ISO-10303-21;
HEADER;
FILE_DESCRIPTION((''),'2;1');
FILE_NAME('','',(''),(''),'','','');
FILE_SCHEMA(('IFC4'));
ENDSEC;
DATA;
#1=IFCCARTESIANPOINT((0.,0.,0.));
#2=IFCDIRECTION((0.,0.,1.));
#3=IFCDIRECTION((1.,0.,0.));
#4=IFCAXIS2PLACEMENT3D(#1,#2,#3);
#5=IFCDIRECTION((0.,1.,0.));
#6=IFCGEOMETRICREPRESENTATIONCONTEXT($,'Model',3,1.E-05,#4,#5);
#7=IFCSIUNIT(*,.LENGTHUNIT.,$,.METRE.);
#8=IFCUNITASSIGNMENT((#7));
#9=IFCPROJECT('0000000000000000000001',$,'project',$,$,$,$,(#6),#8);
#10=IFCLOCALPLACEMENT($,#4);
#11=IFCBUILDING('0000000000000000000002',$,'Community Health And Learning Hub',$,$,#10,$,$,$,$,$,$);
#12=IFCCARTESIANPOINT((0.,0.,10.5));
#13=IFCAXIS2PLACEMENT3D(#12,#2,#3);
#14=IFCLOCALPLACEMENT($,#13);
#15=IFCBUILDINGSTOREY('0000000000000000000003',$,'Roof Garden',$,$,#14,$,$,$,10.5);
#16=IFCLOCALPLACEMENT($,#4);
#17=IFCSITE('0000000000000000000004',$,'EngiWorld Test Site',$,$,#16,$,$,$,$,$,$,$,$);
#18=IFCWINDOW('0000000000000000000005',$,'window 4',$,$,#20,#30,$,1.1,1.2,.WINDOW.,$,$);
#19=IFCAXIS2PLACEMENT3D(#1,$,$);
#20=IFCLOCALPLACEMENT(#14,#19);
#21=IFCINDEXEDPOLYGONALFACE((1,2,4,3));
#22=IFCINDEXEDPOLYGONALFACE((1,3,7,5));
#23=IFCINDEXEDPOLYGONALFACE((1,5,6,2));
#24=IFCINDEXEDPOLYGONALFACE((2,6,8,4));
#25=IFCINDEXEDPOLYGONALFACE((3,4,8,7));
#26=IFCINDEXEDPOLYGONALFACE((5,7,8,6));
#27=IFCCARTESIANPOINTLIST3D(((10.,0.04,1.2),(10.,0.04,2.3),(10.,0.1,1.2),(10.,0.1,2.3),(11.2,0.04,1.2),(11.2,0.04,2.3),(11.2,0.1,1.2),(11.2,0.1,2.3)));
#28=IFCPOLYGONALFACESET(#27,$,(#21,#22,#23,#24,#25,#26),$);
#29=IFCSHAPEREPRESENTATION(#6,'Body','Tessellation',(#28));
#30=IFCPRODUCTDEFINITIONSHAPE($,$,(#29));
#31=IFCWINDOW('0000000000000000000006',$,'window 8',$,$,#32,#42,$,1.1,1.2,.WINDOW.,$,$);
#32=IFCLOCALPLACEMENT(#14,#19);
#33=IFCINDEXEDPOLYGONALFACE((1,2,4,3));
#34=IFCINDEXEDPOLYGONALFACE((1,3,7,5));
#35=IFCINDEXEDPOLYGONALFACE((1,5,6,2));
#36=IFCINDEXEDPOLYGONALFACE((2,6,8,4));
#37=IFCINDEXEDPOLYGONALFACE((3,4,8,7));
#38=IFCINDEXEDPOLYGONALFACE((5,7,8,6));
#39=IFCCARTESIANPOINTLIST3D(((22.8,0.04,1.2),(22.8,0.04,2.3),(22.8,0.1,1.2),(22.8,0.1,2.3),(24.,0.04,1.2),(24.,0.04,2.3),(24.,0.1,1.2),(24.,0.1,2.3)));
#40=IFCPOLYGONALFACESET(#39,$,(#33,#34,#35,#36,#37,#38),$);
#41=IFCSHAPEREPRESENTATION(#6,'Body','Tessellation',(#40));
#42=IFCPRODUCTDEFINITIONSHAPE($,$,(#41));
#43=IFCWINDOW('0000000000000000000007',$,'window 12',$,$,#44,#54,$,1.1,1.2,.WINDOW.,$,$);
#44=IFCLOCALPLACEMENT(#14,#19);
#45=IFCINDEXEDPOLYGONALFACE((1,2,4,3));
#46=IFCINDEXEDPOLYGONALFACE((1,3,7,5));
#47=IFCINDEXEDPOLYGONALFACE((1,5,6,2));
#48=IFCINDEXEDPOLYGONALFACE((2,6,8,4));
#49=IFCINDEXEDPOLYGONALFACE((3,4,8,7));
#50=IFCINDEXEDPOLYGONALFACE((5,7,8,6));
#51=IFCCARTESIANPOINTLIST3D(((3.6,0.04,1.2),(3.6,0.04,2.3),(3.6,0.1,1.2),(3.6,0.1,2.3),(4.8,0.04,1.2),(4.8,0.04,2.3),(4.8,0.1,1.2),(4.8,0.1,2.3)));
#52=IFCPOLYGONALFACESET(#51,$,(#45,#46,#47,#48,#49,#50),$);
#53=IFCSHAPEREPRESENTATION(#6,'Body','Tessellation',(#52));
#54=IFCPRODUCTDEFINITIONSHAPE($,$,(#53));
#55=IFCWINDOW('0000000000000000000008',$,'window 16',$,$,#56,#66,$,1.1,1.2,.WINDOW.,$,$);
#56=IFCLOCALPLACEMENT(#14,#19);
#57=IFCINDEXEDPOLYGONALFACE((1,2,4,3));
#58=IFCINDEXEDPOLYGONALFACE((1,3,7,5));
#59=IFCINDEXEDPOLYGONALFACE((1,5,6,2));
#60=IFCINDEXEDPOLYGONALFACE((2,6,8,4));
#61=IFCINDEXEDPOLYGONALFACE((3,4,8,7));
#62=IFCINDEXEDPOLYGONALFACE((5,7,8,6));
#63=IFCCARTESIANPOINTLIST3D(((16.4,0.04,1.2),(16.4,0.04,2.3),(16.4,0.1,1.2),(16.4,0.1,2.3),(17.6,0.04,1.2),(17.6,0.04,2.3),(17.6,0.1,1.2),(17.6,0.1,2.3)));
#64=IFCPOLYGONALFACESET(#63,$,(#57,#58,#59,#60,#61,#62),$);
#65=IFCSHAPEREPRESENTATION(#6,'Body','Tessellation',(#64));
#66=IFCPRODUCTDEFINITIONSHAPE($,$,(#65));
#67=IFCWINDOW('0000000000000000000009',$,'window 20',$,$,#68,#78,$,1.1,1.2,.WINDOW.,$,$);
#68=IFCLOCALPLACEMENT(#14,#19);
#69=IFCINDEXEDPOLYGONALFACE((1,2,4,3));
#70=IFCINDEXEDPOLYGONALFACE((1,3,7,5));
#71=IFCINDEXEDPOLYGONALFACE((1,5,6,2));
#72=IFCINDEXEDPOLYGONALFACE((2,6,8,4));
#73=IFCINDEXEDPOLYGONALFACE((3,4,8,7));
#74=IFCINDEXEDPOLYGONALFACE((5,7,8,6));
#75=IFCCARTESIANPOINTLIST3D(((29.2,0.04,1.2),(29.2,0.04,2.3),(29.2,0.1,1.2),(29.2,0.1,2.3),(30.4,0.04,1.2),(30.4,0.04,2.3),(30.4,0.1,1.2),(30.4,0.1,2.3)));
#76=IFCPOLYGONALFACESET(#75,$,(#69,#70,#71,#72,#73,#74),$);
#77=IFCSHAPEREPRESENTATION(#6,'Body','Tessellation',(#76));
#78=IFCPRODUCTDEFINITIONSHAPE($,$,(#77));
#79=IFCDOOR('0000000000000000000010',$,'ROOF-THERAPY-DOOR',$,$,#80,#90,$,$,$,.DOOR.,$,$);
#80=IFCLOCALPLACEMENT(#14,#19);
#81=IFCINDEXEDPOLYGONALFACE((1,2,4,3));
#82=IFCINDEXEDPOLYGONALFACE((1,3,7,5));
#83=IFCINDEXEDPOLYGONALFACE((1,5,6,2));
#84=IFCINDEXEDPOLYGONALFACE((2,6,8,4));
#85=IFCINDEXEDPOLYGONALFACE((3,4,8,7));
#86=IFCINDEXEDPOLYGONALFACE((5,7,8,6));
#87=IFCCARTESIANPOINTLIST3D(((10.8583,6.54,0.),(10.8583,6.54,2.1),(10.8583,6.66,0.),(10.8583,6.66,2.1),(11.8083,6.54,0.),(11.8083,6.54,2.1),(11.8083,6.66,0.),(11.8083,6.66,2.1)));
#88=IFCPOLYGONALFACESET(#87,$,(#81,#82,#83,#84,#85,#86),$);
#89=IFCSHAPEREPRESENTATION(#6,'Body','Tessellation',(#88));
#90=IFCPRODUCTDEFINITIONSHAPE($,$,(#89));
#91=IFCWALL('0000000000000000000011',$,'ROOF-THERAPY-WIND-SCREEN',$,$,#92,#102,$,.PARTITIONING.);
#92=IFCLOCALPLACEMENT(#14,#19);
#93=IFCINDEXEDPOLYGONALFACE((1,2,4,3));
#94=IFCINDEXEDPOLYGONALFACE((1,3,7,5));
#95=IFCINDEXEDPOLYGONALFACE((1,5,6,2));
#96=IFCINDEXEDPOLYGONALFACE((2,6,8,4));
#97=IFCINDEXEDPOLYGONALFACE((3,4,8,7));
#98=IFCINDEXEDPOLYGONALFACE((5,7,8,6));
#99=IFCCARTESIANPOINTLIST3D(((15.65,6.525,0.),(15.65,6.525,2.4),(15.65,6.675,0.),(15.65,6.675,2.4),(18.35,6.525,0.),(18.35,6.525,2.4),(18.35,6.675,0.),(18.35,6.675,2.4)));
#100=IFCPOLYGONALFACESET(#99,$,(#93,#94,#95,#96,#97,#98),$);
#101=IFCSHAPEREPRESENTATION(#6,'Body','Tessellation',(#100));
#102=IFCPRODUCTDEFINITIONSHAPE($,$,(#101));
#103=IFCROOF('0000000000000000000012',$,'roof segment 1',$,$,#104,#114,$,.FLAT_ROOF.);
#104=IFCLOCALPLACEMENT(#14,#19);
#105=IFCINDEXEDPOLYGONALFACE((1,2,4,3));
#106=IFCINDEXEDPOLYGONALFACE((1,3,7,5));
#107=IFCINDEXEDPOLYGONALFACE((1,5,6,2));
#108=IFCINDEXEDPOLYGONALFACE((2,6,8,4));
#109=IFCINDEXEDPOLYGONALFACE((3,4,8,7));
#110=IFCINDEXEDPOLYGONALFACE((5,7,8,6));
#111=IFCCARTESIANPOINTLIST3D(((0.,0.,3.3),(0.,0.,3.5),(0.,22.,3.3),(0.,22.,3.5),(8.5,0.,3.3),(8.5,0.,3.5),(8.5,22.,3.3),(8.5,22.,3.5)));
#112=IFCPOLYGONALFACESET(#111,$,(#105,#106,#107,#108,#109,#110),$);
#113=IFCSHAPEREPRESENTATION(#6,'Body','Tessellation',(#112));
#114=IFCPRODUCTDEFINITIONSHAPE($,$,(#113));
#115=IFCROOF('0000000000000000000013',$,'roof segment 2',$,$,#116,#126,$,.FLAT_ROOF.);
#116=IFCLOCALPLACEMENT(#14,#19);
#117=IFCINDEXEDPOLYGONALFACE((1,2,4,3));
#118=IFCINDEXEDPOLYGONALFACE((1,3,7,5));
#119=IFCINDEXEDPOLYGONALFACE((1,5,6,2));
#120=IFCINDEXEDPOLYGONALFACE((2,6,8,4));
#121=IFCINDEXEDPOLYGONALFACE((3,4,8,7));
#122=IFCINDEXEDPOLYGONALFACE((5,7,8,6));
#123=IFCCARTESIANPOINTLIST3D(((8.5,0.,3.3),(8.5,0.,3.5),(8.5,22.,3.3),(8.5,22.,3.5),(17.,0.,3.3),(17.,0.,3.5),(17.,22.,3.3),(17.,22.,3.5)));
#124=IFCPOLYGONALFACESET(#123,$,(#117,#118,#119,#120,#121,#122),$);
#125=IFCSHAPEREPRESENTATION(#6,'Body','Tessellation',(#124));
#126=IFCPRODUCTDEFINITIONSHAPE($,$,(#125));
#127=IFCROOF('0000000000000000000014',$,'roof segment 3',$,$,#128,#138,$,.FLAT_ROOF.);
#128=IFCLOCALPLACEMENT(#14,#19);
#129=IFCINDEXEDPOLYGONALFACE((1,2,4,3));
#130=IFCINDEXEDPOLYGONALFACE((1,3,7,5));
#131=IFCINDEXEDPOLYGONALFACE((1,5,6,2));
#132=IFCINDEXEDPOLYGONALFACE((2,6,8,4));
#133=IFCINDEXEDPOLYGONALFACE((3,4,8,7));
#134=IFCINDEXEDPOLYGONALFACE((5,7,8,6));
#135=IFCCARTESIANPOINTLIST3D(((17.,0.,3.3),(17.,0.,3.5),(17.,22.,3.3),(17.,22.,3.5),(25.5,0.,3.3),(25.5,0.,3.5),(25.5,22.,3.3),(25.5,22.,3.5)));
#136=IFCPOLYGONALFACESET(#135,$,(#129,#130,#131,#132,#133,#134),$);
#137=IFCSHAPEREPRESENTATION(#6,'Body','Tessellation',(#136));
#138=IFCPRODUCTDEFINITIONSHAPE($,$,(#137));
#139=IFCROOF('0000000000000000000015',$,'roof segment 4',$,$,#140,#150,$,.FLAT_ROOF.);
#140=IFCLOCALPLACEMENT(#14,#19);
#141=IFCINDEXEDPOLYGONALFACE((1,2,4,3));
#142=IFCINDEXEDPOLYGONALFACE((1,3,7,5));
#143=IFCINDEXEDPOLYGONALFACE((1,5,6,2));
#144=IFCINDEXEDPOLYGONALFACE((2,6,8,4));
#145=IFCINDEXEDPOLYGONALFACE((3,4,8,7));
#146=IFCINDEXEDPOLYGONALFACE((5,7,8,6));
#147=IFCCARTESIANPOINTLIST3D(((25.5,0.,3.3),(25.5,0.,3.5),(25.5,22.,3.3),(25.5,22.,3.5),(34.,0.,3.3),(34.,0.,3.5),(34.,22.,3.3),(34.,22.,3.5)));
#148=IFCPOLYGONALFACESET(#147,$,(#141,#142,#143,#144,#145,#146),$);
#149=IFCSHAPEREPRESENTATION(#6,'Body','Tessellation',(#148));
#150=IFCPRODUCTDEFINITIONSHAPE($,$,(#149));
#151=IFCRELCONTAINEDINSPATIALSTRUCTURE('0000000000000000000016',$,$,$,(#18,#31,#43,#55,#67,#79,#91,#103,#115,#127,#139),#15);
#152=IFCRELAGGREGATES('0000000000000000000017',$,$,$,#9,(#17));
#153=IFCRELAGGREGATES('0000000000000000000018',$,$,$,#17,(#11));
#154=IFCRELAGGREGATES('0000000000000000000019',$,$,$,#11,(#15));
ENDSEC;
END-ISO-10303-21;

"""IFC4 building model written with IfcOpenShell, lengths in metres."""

from ifc_helpers import new_model, si_unit, direction, frame, origin, origin_with_axes, origin_2d, origin_2d_with_axis, place, context, project, spatial, rectangle, extrude, element, save


model = new_model("IFC4")

# Units and contexts
model_context = context("Model", 3, precision=1e-05, world=origin_with_axes(), true_north=direction((0.0, 1.0, 0.0)))
ifc_project = project(units=[si_unit("LENGTHUNIT", "METRE")], contexts=[model_context])

# Site, building, storey
site_placement = place(None, origin_with_axes())
site = spatial("IfcSite", under=ifc_project, at=site_placement, Name="EngiWorld Test Site")
building_placement = place(None, origin_with_axes())
building = spatial("IfcBuilding", under=site, at=building_placement, Name="Community Health And Learning Hub")
storey_placement = place(None, frame((0.0, 0.0, 10.5), z_axis=(0.0, 0.0, 1.0), x_axis=(1.0, 0.0, 0.0)))
storey = spatial("IfcBuildingStorey", under=building, at=storey_placement, Name="Roof Garden", Elevation=10.5)

# Windows
for number, where, z_axis, x_axis, name in (
    (1, (10.6, 0.07, 11.7), (0.0, 0.0, 1.0), (1.0, 0.0, 0.0), "window 4"),
    (2, (23.4, 0.07, 11.7), (0.0, 0.0, 1.0), (1.0, 0.0, 0.0), "window 8"),
    (3, (4.2, 0.07, 11.7), (0.0, 0.0, 1.0), (1.0, 0.0, 0.0), "window 12"),
    (4, (17.0, 0.07, 11.7), (0.0, 0.0, 1.0), (1.0, 0.0, 0.0), "window 16"),
    (5, (29.8, 0.07, 11.7), (0.0, 0.0, 1.0), (1.0, 0.0, 0.0), "window 20"),
):
    element("IfcWindow", number, at=place(None, frame(where, z_axis=z_axis, x_axis=x_axis)), inside=storey, Name=name, OverallHeight=1.1, OverallWidth=1.2, PredefinedType="WINDOW", context=model_context, shape_type="SweptSolid", body=[
        extrude(rectangle(XDim=1.2, YDim=0.06, at=origin_2d_with_axis()), origin_with_axes(), (0.0, 0.0, 1.0), 1.1),
    ])

# Door
door_placement = place(None, frame((11.3333, 6.6, 10.5)))
element("IfcDoor", 6, at=door_placement, inside=storey, Name="ROOF-THERAPY-DOOR", PredefinedType="DOOR", context=model_context, shape_type="SweptSolid", body=[
    extrude(rectangle(XDim=0.95, YDim=0.12, at=origin_2d()), origin(), (0.0, 0.0, 1.0), 2.1),
])

# Wall
wall_1_placement = place(None, frame((17.0, 6.6, 10.5)))
element("IfcWall", 7, at=wall_1_placement, inside=storey, Name="ROOF-THERAPY-WIND-SCREEN", PredefinedType="PARTITIONING", context=model_context, shape_type="SweptSolid", body=[
    extrude(rectangle(XDim=2.7, YDim=0.15, at=origin_2d()), origin(), (0.0, 0.0, 1.0), 2.4),
])

# Roofs
for number, where, z_axis, x_axis, name in (
    (8, (4.25, 11.0, 13.8), (0.0, 0.0, 1.0), (1.0, 0.0, 0.0), "roof segment 1"),
    (9, (12.75, 11.0, 13.8), (0.0, 0.0, 1.0), (1.0, 0.0, 0.0), "roof segment 2"),
    (10, (21.25, 11.0, 13.8), (0.0, 0.0, 1.0), (1.0, 0.0, 0.0), "roof segment 3"),
    (11, (29.75, 11.0, 13.8), (0.0, 0.0, 1.0), (1.0, 0.0, 0.0), "roof segment 4"),
):
    element("IfcRoof", number, at=place(None, frame(where, z_axis=z_axis, x_axis=x_axis)), inside=storey, Name=name, PredefinedType="FLAT_ROOF", context=model_context, shape_type="SweptSolid", body=[
        extrude(rectangle(XDim=8.5, YDim=22.0, at=origin_2d_with_axis()), origin_with_axes(), (0.0, 0.0, 1.0), 0.2),
    ])

save(model, "model.ifc")
